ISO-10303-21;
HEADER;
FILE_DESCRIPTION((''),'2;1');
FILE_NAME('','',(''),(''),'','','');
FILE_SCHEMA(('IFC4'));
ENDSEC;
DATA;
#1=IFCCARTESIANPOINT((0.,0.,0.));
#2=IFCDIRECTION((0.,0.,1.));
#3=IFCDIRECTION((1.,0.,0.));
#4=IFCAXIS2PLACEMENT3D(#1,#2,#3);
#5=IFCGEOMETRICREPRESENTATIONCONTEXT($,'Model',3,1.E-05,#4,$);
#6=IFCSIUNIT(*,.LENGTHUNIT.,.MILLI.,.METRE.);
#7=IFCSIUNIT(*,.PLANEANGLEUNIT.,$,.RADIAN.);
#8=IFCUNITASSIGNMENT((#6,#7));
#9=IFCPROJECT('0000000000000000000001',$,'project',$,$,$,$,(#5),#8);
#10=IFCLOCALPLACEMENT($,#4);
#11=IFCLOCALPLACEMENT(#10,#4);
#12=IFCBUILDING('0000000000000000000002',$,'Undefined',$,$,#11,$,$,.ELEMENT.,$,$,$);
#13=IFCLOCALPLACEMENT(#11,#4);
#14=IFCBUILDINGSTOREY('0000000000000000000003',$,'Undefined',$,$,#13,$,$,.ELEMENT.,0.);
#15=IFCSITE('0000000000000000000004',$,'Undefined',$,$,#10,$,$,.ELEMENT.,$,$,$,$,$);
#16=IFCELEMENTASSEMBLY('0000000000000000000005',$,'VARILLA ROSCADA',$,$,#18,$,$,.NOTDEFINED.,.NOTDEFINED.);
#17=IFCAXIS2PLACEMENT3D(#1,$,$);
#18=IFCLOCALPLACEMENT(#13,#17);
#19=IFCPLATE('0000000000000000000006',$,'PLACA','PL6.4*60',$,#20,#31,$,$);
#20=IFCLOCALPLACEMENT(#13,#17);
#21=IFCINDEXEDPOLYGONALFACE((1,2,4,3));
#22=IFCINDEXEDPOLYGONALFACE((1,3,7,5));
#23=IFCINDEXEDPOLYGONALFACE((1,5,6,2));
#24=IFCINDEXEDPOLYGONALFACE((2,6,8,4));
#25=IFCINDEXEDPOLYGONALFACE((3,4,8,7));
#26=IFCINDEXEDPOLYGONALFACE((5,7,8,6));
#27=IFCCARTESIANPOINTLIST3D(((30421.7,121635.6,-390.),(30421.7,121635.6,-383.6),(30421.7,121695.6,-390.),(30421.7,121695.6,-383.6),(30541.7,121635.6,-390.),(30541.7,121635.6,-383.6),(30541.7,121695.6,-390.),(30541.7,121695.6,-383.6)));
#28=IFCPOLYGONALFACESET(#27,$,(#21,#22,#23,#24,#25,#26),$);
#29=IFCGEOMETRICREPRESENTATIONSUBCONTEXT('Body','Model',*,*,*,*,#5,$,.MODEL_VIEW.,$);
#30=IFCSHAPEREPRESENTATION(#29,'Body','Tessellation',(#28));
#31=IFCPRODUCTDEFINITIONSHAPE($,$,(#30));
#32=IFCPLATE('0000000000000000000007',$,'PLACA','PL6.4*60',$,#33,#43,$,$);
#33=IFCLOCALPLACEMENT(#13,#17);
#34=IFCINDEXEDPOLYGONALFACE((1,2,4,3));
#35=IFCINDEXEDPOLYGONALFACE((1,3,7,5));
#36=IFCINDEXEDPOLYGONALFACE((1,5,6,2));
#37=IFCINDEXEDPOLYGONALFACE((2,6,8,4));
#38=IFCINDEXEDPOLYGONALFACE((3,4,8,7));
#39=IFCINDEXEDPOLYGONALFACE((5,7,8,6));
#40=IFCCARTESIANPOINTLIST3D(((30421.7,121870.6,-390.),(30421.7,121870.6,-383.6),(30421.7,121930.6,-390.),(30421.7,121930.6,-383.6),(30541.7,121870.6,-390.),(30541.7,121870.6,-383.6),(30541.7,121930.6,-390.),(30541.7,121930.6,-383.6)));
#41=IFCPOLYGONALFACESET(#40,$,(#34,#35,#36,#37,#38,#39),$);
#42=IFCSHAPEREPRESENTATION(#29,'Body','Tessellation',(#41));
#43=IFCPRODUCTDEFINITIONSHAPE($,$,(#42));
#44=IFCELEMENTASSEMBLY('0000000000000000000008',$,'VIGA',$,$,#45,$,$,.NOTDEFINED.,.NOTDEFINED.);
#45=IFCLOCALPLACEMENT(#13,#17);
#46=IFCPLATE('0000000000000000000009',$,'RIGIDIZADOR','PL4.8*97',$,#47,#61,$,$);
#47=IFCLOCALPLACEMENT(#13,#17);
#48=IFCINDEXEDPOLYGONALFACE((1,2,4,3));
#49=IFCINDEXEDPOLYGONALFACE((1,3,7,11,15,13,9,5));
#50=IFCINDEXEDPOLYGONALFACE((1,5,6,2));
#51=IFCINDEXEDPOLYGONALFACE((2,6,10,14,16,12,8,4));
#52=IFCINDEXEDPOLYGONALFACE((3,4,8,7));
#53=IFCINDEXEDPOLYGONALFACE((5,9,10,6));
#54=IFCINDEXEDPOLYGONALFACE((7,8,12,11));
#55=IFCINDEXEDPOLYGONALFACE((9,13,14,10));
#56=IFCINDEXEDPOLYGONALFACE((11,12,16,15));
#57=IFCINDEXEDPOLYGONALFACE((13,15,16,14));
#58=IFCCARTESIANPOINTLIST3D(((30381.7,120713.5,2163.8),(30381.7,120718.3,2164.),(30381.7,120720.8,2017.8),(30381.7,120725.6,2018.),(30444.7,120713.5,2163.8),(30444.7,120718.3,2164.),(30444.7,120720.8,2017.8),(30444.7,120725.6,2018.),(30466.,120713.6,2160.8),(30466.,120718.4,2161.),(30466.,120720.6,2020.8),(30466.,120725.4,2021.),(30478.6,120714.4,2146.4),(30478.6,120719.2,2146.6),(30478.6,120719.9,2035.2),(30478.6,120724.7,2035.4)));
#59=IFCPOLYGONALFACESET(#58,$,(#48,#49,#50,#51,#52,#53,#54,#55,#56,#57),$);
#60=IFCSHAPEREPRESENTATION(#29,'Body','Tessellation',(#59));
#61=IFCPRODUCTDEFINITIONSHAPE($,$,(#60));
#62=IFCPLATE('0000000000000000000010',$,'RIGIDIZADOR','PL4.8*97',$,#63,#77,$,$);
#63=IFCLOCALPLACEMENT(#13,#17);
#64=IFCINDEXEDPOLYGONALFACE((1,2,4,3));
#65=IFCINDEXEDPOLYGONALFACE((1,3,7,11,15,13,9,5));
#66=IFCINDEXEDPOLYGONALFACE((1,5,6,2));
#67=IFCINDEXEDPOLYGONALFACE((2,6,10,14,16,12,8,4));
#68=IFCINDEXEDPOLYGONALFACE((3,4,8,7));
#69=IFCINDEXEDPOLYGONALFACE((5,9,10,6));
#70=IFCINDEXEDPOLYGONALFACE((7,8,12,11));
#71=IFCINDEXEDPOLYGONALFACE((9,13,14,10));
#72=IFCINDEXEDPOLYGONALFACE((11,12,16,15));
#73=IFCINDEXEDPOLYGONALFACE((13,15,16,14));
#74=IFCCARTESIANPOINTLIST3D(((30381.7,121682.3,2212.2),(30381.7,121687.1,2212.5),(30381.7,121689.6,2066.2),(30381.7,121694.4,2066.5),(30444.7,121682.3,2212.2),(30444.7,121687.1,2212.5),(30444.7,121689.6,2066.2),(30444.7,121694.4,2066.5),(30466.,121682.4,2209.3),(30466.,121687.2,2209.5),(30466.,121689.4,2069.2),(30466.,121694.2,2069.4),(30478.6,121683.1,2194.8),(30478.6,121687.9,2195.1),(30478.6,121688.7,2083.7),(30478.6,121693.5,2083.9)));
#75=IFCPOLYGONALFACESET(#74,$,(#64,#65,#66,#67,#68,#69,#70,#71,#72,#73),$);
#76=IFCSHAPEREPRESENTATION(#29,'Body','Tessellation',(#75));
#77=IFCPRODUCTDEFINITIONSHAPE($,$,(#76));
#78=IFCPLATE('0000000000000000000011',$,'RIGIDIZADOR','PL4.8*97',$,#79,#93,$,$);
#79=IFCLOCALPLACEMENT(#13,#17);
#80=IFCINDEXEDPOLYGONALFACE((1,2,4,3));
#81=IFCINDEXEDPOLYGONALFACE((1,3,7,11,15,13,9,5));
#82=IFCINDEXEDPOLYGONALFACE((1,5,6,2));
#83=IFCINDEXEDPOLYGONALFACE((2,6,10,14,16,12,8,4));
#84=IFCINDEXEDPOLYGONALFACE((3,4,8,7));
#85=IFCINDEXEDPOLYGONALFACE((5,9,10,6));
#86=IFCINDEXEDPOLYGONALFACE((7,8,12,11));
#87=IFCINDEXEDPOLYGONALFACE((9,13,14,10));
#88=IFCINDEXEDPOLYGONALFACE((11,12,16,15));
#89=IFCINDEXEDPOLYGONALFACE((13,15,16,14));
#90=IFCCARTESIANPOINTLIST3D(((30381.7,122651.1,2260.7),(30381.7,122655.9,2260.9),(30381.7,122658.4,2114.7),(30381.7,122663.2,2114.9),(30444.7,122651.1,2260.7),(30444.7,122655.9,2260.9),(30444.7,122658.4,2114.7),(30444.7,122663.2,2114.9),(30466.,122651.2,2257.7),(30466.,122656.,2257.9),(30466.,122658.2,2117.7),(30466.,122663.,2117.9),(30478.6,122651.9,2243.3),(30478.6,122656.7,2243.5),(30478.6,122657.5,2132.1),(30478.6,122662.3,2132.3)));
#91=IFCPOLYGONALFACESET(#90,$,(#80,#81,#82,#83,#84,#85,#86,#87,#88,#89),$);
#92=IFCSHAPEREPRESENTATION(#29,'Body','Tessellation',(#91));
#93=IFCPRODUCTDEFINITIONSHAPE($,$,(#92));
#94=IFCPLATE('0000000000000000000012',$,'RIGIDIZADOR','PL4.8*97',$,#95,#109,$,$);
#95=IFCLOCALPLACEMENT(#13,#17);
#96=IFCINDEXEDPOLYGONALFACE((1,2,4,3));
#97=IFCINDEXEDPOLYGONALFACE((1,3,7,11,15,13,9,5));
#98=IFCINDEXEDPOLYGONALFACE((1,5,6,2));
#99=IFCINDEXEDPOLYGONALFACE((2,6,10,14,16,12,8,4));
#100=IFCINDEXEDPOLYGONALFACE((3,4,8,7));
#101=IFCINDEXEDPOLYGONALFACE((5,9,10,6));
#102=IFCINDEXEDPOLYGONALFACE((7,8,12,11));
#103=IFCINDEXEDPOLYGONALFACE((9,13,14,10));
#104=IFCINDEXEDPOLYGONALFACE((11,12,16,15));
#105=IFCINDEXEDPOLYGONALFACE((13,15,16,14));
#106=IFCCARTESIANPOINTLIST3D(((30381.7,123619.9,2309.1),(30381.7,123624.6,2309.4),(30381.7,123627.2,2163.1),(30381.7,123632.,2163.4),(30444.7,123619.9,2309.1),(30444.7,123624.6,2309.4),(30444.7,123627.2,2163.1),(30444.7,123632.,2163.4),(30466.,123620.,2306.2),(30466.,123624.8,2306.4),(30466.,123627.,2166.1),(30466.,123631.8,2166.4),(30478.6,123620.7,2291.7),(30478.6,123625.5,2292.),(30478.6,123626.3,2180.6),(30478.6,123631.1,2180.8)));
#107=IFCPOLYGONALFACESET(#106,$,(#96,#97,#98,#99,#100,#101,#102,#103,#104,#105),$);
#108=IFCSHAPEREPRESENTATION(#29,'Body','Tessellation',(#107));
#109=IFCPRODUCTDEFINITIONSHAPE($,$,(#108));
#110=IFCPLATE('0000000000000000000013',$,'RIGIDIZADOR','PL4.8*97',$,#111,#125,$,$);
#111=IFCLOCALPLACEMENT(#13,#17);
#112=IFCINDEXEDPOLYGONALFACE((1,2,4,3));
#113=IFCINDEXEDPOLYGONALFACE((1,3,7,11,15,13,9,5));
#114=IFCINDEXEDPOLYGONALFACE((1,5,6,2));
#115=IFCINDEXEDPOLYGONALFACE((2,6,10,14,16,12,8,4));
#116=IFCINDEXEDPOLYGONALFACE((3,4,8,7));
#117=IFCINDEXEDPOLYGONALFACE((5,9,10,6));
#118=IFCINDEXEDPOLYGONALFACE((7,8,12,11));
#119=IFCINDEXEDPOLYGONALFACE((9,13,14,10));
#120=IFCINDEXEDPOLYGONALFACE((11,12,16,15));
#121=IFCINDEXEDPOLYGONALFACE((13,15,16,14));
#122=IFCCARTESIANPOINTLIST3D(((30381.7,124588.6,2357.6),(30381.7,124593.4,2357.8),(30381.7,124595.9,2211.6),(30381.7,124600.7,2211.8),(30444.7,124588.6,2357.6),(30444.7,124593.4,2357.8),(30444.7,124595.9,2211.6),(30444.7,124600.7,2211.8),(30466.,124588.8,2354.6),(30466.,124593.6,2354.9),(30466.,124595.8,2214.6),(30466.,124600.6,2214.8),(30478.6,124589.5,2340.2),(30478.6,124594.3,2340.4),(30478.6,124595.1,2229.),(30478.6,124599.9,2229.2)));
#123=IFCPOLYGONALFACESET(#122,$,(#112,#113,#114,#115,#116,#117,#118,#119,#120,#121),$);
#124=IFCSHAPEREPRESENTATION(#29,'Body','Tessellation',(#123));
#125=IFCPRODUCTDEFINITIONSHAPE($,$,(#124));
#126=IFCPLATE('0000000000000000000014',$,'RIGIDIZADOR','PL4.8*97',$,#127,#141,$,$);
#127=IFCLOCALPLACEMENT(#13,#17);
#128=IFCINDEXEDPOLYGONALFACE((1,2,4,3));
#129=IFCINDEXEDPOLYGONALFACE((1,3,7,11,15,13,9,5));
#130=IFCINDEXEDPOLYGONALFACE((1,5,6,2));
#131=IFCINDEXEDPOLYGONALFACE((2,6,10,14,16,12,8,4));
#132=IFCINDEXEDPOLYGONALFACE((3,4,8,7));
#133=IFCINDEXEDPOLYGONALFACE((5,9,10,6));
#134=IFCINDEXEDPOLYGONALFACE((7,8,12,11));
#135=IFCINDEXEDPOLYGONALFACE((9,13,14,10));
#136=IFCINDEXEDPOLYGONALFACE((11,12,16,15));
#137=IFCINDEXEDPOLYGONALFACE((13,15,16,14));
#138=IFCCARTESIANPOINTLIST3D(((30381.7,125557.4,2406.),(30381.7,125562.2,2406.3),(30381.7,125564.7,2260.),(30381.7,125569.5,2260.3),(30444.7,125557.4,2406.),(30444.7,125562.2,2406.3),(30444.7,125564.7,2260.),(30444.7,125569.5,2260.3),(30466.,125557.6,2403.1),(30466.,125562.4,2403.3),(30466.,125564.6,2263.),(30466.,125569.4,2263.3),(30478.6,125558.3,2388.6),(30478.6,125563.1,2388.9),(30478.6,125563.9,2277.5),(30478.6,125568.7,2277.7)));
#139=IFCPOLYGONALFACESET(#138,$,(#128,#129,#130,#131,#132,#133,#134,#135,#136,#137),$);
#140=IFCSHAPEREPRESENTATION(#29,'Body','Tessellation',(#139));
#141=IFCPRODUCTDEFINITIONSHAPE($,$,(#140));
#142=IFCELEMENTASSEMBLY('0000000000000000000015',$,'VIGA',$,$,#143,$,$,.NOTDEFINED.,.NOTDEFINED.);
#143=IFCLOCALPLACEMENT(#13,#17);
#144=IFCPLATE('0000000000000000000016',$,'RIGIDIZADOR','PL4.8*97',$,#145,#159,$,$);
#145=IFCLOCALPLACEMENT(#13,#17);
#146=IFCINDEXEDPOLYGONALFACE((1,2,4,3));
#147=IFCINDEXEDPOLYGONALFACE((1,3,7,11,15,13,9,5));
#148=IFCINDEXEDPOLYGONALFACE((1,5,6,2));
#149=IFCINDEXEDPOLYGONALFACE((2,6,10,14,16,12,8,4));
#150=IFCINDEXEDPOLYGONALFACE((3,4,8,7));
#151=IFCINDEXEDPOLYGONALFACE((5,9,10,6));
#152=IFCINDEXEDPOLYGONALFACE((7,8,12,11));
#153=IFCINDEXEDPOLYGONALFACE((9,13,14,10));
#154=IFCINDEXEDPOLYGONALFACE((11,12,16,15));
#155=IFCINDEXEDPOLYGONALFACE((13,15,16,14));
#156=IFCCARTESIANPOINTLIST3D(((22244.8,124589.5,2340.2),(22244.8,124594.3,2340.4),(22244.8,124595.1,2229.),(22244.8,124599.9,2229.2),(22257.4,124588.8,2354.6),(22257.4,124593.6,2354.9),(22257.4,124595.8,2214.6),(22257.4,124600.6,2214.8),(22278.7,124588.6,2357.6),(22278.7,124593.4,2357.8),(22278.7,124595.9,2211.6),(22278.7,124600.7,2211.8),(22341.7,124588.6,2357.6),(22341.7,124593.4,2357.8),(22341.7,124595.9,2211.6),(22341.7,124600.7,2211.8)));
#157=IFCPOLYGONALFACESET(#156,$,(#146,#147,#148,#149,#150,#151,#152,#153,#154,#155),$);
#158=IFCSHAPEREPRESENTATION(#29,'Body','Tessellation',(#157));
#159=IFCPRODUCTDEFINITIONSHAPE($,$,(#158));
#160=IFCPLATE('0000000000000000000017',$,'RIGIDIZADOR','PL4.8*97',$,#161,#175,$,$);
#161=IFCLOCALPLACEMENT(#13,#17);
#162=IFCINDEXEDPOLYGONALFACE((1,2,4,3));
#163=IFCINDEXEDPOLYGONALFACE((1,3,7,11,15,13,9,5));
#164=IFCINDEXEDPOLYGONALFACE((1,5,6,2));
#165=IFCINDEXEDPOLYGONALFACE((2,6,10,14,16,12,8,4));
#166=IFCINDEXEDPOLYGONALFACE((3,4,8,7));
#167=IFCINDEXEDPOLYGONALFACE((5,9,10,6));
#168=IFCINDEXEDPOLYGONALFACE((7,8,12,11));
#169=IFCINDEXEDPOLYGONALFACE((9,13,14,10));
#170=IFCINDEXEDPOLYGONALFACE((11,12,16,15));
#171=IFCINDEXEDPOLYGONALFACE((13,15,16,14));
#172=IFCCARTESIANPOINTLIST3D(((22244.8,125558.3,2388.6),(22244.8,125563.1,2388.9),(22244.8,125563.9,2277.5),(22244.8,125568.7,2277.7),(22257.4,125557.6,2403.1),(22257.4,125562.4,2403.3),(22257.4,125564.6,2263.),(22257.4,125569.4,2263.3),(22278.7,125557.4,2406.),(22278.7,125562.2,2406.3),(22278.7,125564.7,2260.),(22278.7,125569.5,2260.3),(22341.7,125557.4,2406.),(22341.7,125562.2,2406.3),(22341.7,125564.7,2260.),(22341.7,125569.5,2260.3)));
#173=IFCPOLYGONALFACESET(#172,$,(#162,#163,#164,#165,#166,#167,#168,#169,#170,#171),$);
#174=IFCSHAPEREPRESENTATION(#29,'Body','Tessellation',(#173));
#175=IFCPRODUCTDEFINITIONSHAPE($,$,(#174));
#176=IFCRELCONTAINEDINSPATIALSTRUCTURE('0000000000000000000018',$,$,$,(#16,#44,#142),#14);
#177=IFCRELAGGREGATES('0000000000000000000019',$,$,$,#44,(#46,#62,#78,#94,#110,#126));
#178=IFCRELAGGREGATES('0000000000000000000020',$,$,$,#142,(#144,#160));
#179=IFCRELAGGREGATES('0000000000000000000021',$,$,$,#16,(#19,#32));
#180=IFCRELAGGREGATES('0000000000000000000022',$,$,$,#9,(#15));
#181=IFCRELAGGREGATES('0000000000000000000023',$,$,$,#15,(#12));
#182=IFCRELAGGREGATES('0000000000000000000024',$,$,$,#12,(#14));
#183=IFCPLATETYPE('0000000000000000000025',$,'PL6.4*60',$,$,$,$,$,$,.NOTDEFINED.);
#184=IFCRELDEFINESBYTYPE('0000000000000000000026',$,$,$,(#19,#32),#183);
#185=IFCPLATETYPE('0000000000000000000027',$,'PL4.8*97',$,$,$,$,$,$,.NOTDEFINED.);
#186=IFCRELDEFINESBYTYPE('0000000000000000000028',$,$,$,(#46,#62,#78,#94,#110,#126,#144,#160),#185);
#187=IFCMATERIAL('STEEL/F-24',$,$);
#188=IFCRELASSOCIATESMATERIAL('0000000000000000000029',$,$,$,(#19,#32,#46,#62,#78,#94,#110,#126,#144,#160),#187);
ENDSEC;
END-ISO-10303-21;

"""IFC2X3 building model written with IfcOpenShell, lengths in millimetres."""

from ifc_helpers import new_model, si_unit, frame, origin_with_axes, place, context, subcontext, project, spatial, polyline, outline, extrude, material, type_object, element, aggregate, save


model = new_model("IFC2X3")

# Units and contexts
model_context = context("Model", 3, precision=1e-05, world=origin_with_axes())
body_context = subcontext(model_context, "Body", "Model", "MODEL_VIEW")
ifc_project = project(units=[si_unit("LENGTHUNIT", "METRE", prefix="MILLI"), si_unit("PLANEANGLEUNIT", "RADIAN")], contexts=[model_context])

# Site, building, storey
site_placement = place(None, origin_with_axes())
site = spatial("IfcSite", under=ifc_project, at=site_placement, Name="Undefined", CompositionType="ELEMENT")
building_placement = place(site_placement, origin_with_axes())
building = spatial("IfcBuilding", under=site, at=building_placement, Name="Undefined", CompositionType="ELEMENT")
storey_placement = place(building_placement, origin_with_axes())
storey = spatial("IfcBuildingStorey", under=building, at=storey_placement, Name="Undefined", CompositionType="ELEMENT", Elevation=0.0)

# Element assemblies, plates
ifc_material_1 = material(Name="STEEL/F-24")
assembly_1_placement = place(storey_placement, origin_with_axes())
assembly_1 = element("IfcElementAssembly", 1, at=assembly_1_placement, inside=storey, Name="VARILLA ROSCADA", AssemblyPlace="NOTDEFINED", PredefinedType="NOTDEFINED")
plate_type_1 = type_object("IfcPlateType", Name="PL6.4*60", PredefinedType="NOTDEFINED")
plate_1_placement = place(assembly_1_placement, frame((30421.7, 121635.6, -386.8), z_axis=(0.0, 0.0, 1.0), x_axis=(1.0, 0.0, 0.0)))
plate_1 = element("IfcPlate", 2, at=plate_1_placement, type_object=plate_type_1, material=ifc_material_1, Name="PLACA", Description="PL6.4*60", context=body_context, shape_type="SweptSolid", body=[
    extrude(outline(polyline([(0.0, 0.0), (120.0, 0.0), (120.0, 60.0), (0.0, 60.0), (0.0, 0.0)])), frame((0.0, 0.0, -3.2), z_axis=(0.0, 0.0, 1.0), x_axis=(1.0, 0.0, 0.0)), (0.0, 0.0, 1.0), 6.4),
])
plate_2_placement = place(assembly_1_placement, frame((30421.7, 121870.6, -386.8), z_axis=(0.0, 0.0, 1.0), x_axis=(1.0, 0.0, 0.0)))
plate_2 = element("IfcPlate", 3, at=plate_2_placement, type_object=plate_type_1, material=ifc_material_1, Name="PLACA", Description="PL6.4*60", context=body_context, shape_type="SweptSolid", body=[
    extrude(outline(polyline([(0.0, 0.0), (120.0, 0.0), (120.0, 60.0), (0.0, 60.0), (0.0, 0.0)])), frame((0.0, 0.0, -3.2), z_axis=(0.0, 0.0, 1.0), x_axis=(1.0, 0.0, 0.0)), (0.0, 0.0, 1.0), 6.4),
])
assembly_2_placement = place(storey_placement, origin_with_axes())
assembly_2 = element("IfcElementAssembly", 4, at=assembly_2_placement, inside=storey, Name="VIGA", AssemblyPlace="NOTDEFINED", PredefinedType="NOTDEFINED")
plate_type_2 = type_object("IfcPlateType", Name="PL4.8*97", PredefinedType="NOTDEFINED")
plate_3_placement = place(assembly_2_placement, frame((30381.7, 120715.9, 2163.9), z_axis=(0.0, 0.998752, 0.04995), x_axis=(1.0, 0.0, 0.0)))
plate_3 = element("IfcPlate", 5, at=plate_3_placement, type_object=plate_type_2, material=ifc_material_1, Name="RIGIDIZADOR", Description="PL4.8*97", context=body_context, shape_type="SweptSolid", body=[
    extrude(outline(polyline([(0.0, 0.0), (63.0, 0.0), (84.3, 3.0), (96.8, 17.4), (96.8, 128.7), (84.3, 143.2), (63.0, 146.2), (0.0, 146.2), (0.0, 0.0)])), frame((0.0, 0.0, -2.4), z_axis=(0.0, 0.0, 1.0), x_axis=(1.0, 0.0, 0.0)), (0.0, 0.0, 1.0), 4.8),
])
plate_4_placement = place(assembly_2_placement, frame((30381.7, 121684.7, 2212.4), z_axis=(0.0, 0.998752, 0.04995), x_axis=(1.0, 0.0, 0.0)))
plate_4 = element("IfcPlate", 6, at=plate_4_placement, type_object=plate_type_2, material=ifc_material_1, Name="RIGIDIZADOR", Description="PL4.8*97", context=body_context, shape_type="SweptSolid", body=[
    extrude(outline(polyline([(0.0, 0.0), (63.0, 0.0), (84.3, 3.0), (96.8, 17.4), (96.8, 128.7), (84.3, 143.2), (63.0, 146.2), (0.0, 146.2), (0.0, 0.0)])), frame((0.0, 0.0, -2.4), z_axis=(0.0, 0.0, 1.0), x_axis=(1.0, 0.0, 0.0)), (0.0, 0.0, 1.0), 4.8),
])
plate_5_placement = place(assembly_2_placement, frame((30381.7, 122653.5, 2260.8), z_axis=(0.0, 0.998752, 0.04995), x_axis=(1.0, 0.0, 0.0)))
plate_5 = element("IfcPlate", 7, at=plate_5_placement, type_object=plate_type_2, material=ifc_material_1, Name="RIGIDIZADOR", Description="PL4.8*97", context=body_context, shape_type="SweptSolid", body=[
    extrude(outline(polyline([(0.0, 0.0), (63.0, 0.0), (84.3, 3.0), (96.8, 17.4), (96.8, 128.7), (84.3, 143.2), (63.0, 146.2), (0.0, 146.2), (0.0, 0.0)])), frame((0.0, 0.0, -2.4), z_axis=(0.0, 0.0, 1.0), x_axis=(1.0, 0.0, 0.0)), (0.0, 0.0, 1.0), 4.8),
])
plate_6_placement = place(assembly_2_placement, frame((30381.7, 123622.3, 2309.3), z_axis=(0.0, 0.998752, 0.04995), x_axis=(1.0, 0.0, 0.0)))
plate_6 = element("IfcPlate", 8, at=plate_6_placement, type_object=plate_type_2, material=ifc_material_1, Name="RIGIDIZADOR", Description="PL4.8*97", context=body_context, shape_type="SweptSolid", body=[
    extrude(outline(polyline([(0.0, 0.0), (63.0, 0.0), (84.3, 3.0), (96.8, 17.4), (96.8, 128.7), (84.3, 143.2), (63.0, 146.2), (0.0, 146.2), (0.0, 0.0)])), frame((0.0, 0.0, -2.4), z_axis=(0.0, 0.0, 1.0), x_axis=(1.0, 0.0, 0.0)), (0.0, 0.0, 1.0), 4.8),
])
plate_7_placement = place(assembly_2_placement, frame((30381.7, 124591.0, 2357.7), z_axis=(0.0, 0.998752, 0.04995), x_axis=(1.0, 0.0, 0.0)))
plate_7 = element("IfcPlate", 9, at=plate_7_placement, type_object=plate_type_2, material=ifc_material_1, Name="RIGIDIZADOR", Description="PL4.8*97", context=body_context, shape_type="SweptSolid", body=[
    extrude(outline(polyline([(0.0, 0.0), (63.0, 0.0), (84.3, 3.0), (96.8, 17.4), (96.8, 128.7), (84.3, 143.2), (63.0, 146.2), (0.0, 146.2), (0.0, 0.0)])), frame((0.0, 0.0, -2.4), z_axis=(0.0, 0.0, 1.0), x_axis=(1.0, 0.0, 0.0)), (0.0, 0.0, 1.0), 4.8),
])
plate_8_placement = place(assembly_2_placement, frame((30381.7, 125559.8, 2406.2), z_axis=(0.0, 0.998752, 0.04995), x_axis=(1.0, 0.0, 0.0)))
plate_8 = element("IfcPlate", 10, at=plate_8_placement, type_object=plate_type_2, material=ifc_material_1, Name="RIGIDIZADOR", Description="PL4.8*97", context=body_context, shape_type="SweptSolid", body=[
    extrude(outline(polyline([(0.0, 0.0), (63.0, 0.0), (84.3, 3.0), (96.8, 17.4), (96.8, 128.7), (84.3, 143.2), (63.0, 146.2), (0.0, 146.2), (0.0, 0.0)])), frame((0.0, 0.0, -2.4), z_axis=(0.0, 0.0, 1.0), x_axis=(1.0, 0.0, 0.0)), (0.0, 0.0, 1.0), 4.8),
])
aggregate(assembly_2, [plate_3, plate_4, plate_5, plate_6, plate_7, plate_8])
assembly_3_placement = place(storey_placement, origin_with_axes())
assembly_3 = element("IfcElementAssembly", 11, at=assembly_3_placement, inside=storey, Name="VIGA", AssemblyPlace="NOTDEFINED", PredefinedType="NOTDEFINED")
plate_9_placement = place(assembly_3_placement, frame((22341.7, 124591.0, 2357.7), z_axis=(0.0, -0.998752, -0.04995), x_axis=(-1.0, 0.0, 0.0)))
plate_9 = element("IfcPlate", 12, at=plate_9_placement, type_object=plate_type_2, material=ifc_material_1, Name="RIGIDIZADOR", Description="PL4.8*97", context=body_context, shape_type="SweptSolid", body=[
    extrude(outline(polyline([(0.0, 0.0), (63.0, 0.0), (84.3, 3.0), (96.8, 17.4), (96.8, 128.7), (84.3, 143.2), (63.0, 146.2), (0.0, 146.2), (0.0, 0.0)])), frame((0.0, 0.0, -2.4), z_axis=(0.0, 0.0, 1.0), x_axis=(1.0, 0.0, 0.0)), (0.0, 0.0, 1.0), 4.8),
])
plate_10_placement = place(assembly_3_placement, frame((22341.7, 125559.8, 2406.2), z_axis=(0.0, -0.998752, -0.04995), x_axis=(-1.0, 0.0, 0.0)))
plate_10 = element("IfcPlate", 13, at=plate_10_placement, type_object=plate_type_2, material=ifc_material_1, Name="RIGIDIZADOR", Description="PL4.8*97", context=body_context, shape_type="SweptSolid", body=[
    extrude(outline(polyline([(0.0, 0.0), (63.0, 0.0), (84.3, 3.0), (96.8, 17.4), (96.8, 128.7), (84.3, 143.2), (63.0, 146.2), (0.0, 146.2), (0.0, 0.0)])), frame((0.0, 0.0, -2.4), z_axis=(0.0, 0.0, 1.0), x_axis=(1.0, 0.0, 0.0)), (0.0, 0.0, 1.0), 4.8),
])
aggregate(assembly_3, [plate_9, plate_10])

aggregate(assembly_1, [plate_1, plate_2])

save(model, "model.ifc")
